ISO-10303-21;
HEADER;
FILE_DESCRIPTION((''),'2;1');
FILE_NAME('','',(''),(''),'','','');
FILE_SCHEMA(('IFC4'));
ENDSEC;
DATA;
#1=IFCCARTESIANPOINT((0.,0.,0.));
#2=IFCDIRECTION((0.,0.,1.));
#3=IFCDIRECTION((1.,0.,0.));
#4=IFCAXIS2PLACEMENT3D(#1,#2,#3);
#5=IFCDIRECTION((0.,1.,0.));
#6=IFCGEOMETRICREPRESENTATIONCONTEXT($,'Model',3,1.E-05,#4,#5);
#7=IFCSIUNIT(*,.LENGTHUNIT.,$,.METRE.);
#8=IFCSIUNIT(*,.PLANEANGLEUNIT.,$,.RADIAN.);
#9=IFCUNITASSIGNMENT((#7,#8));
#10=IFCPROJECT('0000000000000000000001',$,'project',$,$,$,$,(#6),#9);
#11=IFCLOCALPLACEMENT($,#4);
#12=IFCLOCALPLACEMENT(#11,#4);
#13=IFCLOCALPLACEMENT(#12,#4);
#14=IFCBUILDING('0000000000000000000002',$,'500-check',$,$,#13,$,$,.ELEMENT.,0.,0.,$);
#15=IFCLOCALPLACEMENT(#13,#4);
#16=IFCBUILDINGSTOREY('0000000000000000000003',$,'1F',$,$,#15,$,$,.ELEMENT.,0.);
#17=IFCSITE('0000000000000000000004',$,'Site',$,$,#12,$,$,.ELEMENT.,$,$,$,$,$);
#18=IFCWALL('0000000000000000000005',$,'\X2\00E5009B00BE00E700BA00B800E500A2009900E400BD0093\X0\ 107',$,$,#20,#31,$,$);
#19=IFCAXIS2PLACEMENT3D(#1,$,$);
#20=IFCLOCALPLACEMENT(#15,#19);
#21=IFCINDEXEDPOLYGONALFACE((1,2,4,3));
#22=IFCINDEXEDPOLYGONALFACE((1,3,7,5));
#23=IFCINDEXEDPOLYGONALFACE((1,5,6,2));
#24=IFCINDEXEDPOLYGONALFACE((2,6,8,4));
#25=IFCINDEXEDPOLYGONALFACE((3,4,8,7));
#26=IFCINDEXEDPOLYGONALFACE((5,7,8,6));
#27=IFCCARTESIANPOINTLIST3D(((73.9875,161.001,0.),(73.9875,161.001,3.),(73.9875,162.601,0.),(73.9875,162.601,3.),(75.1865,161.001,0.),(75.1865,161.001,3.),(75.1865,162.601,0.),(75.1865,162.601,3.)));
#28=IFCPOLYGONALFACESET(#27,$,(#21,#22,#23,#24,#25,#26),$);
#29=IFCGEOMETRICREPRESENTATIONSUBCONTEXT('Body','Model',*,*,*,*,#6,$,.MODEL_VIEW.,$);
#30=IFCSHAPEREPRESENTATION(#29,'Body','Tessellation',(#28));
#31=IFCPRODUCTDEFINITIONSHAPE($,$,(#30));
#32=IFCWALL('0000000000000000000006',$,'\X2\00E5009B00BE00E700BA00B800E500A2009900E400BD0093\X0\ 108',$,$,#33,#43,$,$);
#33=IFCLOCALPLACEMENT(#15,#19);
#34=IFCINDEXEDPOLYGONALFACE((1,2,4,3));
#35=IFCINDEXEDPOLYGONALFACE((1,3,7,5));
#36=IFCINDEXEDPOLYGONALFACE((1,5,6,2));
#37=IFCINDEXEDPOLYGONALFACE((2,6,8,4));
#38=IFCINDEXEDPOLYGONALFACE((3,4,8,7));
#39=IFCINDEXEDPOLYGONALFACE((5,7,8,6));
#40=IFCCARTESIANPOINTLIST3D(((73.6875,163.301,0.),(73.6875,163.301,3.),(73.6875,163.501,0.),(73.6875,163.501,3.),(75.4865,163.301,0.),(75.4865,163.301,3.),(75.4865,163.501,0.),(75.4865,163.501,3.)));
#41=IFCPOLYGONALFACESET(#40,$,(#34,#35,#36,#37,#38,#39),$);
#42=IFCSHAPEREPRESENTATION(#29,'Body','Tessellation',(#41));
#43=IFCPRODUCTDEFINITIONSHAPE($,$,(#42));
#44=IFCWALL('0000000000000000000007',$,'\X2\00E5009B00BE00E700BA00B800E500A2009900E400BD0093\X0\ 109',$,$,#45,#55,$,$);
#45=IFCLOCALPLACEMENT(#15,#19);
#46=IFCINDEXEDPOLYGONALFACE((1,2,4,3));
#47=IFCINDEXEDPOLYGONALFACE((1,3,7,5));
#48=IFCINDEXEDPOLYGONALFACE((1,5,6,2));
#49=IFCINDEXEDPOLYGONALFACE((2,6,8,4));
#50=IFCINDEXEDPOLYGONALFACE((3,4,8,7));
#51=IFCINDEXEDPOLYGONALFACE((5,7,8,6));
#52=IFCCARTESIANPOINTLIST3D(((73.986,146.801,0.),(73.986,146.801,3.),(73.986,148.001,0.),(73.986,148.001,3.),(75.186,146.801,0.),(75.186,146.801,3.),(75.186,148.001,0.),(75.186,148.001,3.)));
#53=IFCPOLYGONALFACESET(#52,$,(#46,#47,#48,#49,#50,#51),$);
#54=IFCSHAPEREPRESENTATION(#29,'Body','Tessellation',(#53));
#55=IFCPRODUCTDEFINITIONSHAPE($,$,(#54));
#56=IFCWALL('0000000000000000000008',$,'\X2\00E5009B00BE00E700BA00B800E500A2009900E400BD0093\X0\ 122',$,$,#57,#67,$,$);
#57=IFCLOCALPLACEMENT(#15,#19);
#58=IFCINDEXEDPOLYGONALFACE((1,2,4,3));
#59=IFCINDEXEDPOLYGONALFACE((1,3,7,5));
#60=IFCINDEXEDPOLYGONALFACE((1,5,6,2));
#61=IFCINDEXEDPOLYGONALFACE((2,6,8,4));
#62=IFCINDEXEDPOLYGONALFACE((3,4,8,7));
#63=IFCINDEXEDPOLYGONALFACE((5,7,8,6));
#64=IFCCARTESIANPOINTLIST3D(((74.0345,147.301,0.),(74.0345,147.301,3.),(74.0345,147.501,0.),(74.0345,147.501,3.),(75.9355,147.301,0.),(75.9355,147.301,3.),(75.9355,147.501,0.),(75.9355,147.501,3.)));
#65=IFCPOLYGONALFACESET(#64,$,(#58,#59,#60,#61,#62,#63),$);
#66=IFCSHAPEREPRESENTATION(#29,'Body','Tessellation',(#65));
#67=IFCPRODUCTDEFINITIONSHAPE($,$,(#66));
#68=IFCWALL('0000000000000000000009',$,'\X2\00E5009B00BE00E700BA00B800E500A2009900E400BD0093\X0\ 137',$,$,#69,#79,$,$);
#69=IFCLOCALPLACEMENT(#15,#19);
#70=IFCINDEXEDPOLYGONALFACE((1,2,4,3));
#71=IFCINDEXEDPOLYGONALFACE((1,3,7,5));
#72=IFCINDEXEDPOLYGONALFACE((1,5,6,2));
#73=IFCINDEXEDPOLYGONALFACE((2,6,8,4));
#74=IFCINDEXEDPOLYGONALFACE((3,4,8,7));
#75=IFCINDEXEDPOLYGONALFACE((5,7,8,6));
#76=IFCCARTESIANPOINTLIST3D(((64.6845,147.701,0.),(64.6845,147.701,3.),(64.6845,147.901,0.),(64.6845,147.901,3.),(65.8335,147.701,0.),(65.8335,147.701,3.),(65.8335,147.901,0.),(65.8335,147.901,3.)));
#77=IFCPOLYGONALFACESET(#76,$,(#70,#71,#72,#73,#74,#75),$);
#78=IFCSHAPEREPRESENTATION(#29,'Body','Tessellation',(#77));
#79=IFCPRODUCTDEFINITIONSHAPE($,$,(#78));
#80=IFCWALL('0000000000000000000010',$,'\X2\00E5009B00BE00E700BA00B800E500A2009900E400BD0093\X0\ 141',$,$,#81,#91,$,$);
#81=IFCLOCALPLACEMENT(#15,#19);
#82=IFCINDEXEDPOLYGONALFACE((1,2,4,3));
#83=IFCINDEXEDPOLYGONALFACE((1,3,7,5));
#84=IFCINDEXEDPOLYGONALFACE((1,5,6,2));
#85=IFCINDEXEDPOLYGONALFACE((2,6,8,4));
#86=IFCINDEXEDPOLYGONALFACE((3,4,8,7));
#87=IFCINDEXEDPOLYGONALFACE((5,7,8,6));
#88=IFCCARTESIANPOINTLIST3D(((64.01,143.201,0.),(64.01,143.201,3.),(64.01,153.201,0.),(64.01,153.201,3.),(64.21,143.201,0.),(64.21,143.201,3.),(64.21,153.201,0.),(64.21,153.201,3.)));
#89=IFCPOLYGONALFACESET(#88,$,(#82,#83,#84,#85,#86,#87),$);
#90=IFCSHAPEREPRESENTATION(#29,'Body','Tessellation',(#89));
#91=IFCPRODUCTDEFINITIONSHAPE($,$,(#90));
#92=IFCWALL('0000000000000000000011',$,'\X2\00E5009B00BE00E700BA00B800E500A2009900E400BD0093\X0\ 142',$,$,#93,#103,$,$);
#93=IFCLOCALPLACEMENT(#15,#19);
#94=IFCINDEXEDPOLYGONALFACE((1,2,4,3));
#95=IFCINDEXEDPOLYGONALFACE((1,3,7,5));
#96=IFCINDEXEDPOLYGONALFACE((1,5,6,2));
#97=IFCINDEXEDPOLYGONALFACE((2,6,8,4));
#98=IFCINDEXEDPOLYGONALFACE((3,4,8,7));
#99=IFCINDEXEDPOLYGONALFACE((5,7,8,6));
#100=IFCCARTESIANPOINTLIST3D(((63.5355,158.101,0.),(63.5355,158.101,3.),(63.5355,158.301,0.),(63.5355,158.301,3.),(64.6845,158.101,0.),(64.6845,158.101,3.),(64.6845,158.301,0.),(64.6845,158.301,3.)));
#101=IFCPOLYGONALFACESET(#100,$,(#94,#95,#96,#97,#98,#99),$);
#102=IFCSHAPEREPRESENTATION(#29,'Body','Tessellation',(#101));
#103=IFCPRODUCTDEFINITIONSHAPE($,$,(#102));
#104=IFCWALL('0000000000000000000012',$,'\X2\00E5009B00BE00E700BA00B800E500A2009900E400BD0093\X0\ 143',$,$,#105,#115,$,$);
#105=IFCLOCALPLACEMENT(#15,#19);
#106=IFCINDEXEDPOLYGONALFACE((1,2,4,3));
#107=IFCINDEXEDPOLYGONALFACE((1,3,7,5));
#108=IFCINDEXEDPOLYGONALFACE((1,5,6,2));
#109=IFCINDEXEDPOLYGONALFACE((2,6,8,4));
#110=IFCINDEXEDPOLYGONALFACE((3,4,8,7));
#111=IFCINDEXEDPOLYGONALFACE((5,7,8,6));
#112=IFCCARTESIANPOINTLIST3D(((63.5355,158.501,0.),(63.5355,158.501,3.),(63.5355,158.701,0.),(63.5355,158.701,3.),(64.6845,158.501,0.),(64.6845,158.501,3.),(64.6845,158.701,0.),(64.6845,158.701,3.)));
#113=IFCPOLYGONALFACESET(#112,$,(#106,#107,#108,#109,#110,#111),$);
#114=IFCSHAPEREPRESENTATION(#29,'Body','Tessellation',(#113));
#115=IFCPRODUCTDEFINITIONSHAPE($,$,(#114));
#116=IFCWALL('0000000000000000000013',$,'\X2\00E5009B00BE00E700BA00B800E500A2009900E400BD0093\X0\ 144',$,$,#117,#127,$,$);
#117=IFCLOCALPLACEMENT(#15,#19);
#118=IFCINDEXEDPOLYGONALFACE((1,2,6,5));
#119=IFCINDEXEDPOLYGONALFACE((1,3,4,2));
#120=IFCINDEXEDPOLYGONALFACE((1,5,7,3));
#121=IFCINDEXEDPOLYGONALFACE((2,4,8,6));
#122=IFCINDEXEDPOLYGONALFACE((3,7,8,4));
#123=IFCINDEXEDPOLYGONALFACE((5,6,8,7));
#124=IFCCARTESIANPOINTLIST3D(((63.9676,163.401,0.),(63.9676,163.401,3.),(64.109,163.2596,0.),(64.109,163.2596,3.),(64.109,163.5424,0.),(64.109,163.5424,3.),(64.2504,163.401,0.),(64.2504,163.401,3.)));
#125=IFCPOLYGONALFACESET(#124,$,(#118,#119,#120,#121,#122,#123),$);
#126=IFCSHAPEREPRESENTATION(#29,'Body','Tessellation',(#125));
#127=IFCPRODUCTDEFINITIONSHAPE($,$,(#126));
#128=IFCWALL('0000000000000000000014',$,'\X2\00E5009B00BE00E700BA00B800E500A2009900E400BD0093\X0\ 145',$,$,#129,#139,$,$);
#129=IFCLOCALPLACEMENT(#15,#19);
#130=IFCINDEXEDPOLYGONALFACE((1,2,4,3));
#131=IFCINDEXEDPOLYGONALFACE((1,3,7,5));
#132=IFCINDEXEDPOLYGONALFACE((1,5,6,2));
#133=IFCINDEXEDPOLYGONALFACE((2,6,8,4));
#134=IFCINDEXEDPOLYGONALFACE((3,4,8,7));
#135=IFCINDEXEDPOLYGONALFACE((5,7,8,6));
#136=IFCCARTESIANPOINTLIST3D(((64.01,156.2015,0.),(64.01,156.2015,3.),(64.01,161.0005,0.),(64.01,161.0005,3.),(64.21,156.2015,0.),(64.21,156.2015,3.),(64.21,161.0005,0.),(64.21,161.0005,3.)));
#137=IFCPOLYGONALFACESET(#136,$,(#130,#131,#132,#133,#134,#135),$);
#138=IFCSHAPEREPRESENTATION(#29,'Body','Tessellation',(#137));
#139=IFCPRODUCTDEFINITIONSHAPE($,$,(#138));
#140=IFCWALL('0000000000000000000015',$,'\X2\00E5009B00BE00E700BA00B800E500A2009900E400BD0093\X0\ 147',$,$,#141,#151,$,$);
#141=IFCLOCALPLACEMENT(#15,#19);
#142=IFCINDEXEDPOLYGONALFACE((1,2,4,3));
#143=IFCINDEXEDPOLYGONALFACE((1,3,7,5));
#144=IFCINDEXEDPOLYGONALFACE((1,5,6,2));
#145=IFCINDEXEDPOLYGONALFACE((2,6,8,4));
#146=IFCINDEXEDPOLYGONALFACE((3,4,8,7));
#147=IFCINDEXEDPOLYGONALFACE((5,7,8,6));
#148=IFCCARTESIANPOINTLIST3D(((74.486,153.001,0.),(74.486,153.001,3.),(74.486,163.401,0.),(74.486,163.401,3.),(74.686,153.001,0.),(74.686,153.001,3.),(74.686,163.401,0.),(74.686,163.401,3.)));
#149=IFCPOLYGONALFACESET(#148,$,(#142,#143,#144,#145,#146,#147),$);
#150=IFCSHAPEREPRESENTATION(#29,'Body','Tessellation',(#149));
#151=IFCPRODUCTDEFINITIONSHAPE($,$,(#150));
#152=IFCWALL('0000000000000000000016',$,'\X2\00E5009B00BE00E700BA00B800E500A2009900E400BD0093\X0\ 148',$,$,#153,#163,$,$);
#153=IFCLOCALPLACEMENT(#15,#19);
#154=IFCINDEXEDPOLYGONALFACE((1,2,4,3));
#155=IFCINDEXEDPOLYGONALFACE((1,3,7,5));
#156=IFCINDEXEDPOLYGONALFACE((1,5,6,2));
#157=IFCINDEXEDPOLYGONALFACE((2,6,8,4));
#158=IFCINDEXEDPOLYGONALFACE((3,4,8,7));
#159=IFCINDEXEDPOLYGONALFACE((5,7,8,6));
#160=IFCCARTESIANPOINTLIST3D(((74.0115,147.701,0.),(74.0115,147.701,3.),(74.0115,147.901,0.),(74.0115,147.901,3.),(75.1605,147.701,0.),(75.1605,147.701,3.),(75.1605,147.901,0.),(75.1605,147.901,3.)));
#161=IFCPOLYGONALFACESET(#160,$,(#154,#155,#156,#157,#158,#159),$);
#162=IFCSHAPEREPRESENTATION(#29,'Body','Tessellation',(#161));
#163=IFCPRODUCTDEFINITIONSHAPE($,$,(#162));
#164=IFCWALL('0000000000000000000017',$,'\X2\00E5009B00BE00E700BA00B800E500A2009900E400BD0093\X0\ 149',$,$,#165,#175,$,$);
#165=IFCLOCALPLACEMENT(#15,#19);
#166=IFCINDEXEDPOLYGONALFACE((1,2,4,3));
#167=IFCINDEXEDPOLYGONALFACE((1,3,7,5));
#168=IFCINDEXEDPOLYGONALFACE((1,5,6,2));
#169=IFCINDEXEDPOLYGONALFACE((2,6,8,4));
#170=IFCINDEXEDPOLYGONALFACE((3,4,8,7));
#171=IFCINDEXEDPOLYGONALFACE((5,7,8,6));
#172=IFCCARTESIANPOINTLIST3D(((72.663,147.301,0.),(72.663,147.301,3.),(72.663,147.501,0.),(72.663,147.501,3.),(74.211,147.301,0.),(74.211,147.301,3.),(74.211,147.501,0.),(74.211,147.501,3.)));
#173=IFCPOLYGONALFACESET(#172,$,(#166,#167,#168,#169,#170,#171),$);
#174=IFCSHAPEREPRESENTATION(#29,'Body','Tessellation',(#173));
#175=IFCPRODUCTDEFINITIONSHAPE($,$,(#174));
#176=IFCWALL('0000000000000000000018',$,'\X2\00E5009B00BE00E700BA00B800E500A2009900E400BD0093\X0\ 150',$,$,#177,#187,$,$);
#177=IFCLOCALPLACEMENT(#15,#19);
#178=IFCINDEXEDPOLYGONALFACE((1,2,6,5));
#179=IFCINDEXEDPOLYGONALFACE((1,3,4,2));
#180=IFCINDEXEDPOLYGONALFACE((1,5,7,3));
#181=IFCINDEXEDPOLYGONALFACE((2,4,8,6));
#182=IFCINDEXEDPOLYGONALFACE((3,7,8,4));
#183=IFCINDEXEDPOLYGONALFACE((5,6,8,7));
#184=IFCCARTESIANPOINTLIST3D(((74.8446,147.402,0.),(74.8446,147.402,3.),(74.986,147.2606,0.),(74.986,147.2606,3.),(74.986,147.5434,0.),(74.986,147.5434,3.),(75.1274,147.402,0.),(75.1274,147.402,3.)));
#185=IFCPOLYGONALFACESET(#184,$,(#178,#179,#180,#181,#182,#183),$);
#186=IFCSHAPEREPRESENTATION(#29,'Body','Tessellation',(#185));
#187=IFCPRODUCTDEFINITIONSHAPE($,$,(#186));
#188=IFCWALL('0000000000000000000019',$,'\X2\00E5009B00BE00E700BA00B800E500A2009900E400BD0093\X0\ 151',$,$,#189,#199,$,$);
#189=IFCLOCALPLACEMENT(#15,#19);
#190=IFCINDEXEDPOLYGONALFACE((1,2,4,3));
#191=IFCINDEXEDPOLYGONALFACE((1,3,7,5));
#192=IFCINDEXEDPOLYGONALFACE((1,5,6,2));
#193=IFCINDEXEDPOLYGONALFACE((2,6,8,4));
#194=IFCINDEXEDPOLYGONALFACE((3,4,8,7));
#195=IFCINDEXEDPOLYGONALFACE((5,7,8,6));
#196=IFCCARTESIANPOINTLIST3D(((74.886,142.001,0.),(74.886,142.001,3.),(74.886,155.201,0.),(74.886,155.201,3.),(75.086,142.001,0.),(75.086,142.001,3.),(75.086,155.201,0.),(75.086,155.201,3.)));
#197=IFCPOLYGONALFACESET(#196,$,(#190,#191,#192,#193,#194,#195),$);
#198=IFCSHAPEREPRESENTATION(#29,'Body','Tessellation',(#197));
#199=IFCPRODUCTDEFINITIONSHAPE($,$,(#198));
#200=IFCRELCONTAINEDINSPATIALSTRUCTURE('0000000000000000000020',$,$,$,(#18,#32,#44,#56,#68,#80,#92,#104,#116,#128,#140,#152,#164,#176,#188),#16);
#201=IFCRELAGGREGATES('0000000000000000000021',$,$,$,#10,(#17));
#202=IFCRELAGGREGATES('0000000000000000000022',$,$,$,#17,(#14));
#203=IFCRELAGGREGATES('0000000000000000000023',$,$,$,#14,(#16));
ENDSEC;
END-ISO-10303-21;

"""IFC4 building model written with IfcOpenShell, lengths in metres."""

from ifc_helpers import new_model, si_unit, direction, frame, frame_2d, origin_with_axes, place, context, subcontext, project, spatial, rectangle, extrude, element, save


model = new_model("IFC4")

# Units and contexts
model_context = context("Model", 3, precision=1e-05, world=origin_with_axes(), true_north=direction((0.0, 1.0, 0.0)))
body_context = subcontext(model_context, "Body", "Model", "MODEL_VIEW")
ifc_project = project(units=[si_unit("LENGTHUNIT", "METRE"), si_unit("PLANEANGLEUNIT", "RADIAN")], contexts=[model_context])

# Site, building, storey
placement = place(None, origin_with_axes())
site_placement = place(placement, origin_with_axes())
site = spatial("IfcSite", under=ifc_project, at=site_placement, Name="Site", CompositionType="ELEMENT")
building_placement = place(site_placement, origin_with_axes())
building = spatial("IfcBuilding", under=site, at=building_placement, Name="500-check", CompositionType="ELEMENT", ElevationOfRefHeight=0.0, ElevationOfTerrain=0.0)
storey_placement = place(building_placement, origin_with_axes())
storey = spatial("IfcBuildingStorey", under=building, at=storey_placement, Name="1F", CompositionType="ELEMENT", Elevation=0.0)

# Walls
wall_1_placement = place(storey_placement, frame((74.587, 161.801, 0.0), z_axis=(0.0, 0.0, 1.0), x_axis=(1.0, 0.0, 0.0)))
element("IfcWall", 1, at=wall_1_placement, inside=storey, Name="å\u009b¾çº¸å¢\u0099ä½\u0093 107", context=body_context, shape_type="SweptSolid", body=[
    extrude(rectangle(XDim=1.199, YDim=1.6, at=frame_2d((0.0, 0.0), x_axis=(1.0, 0.0, 0.0))), frame((0.0, 0.0, 0.0), z_axis=(0.0, 0.0, 1.0)), (0.0, 0.0, 1.0), 3.0),
])
wall_2_placement = place(storey_placement, frame((74.587, 163.401, 0.0), z_axis=(0.0, 0.0, 1.0), x_axis=(1.0, 0.0, 0.0)))
element("IfcWall", 2, at=wall_2_placement, inside=storey, Name="å\u009b¾çº¸å¢\u0099ä½\u0093 108", context=body_context, shape_type="SweptSolid", body=[
    extrude(rectangle(XDim=1.799, YDim=0.2, at=frame_2d((0.0, 0.0), x_axis=(1.0, 0.0, 0.0))), frame((0.0, 0.0, 0.0), z_axis=(0.0, 0.0, 1.0)), (0.0, 0.0, 1.0), 3.0),
])
wall_3_placement = place(storey_placement, frame((74.586, 147.401, 0.0), z_axis=(0.0, 0.0, 1.0), x_axis=(1.0, 0.0, 0.0)))
element("IfcWall", 3, at=wall_3_placement, inside=storey, Name="å\u009b¾çº¸å¢\u0099ä½\u0093 109", context=body_context, shape_type="SweptSolid", body=[
    extrude(rectangle(XDim=1.2, YDim=1.2, at=frame_2d((0.0, 0.0), x_axis=(1.0, 0.0, 0.0))), frame((0.0, 0.0, 0.0), z_axis=(0.0, 0.0, 1.0)), (0.0, 0.0, 1.0), 3.0),
])
wall_4_placement = place(storey_placement, frame((74.985, 147.401, 0.0), z_axis=(0.0, 0.0, 1.0), x_axis=(1.0, 0.0, 0.0)))
element("IfcWall", 4, at=wall_4_placement, inside=storey, Name="å\u009b¾çº¸å¢\u0099ä½\u0093 122", context=body_context, shape_type="SweptSolid", body=[
    extrude(rectangle(XDim=1.901, YDim=0.2, at=frame_2d((0.0, 0.0), x_axis=(1.0, 0.0, 0.0))), frame((0.0, 0.0, 0.0), z_axis=(0.0, 0.0, 1.0)), (0.0, 0.0, 1.0), 3.0),
])
wall_5_placement = place(storey_placement, frame((65.259, 147.801, 0.0), z_axis=(0.0, 0.0, 1.0), x_axis=(-1.0, 0.0, 0.0)))
element("IfcWall", 5, at=wall_5_placement, inside=storey, Name="å\u009b¾çº¸å¢\u0099ä½\u0093 137", context=body_context, shape_type="SweptSolid", body=[
    extrude(rectangle(XDim=1.149, YDim=0.2, at=frame_2d((0.0, 0.0), x_axis=(1.0, 0.0, 0.0))), frame((0.0, 0.0, 0.0), z_axis=(0.0, 0.0, 1.0)), (0.0, 0.0, 1.0), 3.0),
])
wall_6_placement = place(storey_placement, frame((64.11, 148.201, 0.0), z_axis=(0.0, 0.0, 1.0), x_axis=(0.0, 1.0, 0.0)))
element("IfcWall", 6, at=wall_6_placement, inside=storey, Name="å\u009b¾çº¸å¢\u0099ä½\u0093 141", context=body_context, shape_type="SweptSolid", body=[
    extrude(rectangle(XDim=10.0, YDim=0.2, at=frame_2d((0.0, 0.0), x_axis=(1.0, 0.0, 0.0))), frame((0.0, 0.0, 0.0), z_axis=(0.0, 0.0, 1.0)), (0.0, 0.0, 1.0), 3.0),
])
for number, where, z_axis, x_axis, name in (
    (7, (64.11, 158.201, 0.0), (0.0, 0.0, 1.0), (1.0, 0.0, 0.0), "å\u009b¾çº¸å¢\u0099ä½\u0093 142"),
    (8, (64.11, 158.601, 0.0), (0.0, 0.0, 1.0), (1.0, 0.0, 0.0), "å\u009b¾çº¸å¢\u0099ä½\u0093 143"),
):
    element("IfcWall", number, at=place(storey_placement, frame(where, z_axis=z_axis, x_axis=x_axis)), inside=storey, Name=name, context=body_context, shape_type="SweptSolid", body=[
        extrude(rectangle(XDim=1.149, YDim=0.2, at=frame_2d((0.0, 0.0), x_axis=(1.0, 0.0, 0.0))), frame((0.0, 0.0, 0.0), z_axis=(0.0, 0.0, 1.0)), (0.0, 0.0, 1.0), 3.0),
    ])
wall_7_placement = place(storey_placement, frame((64.109, 163.401, 0.0), z_axis=(0.0, 0.0, 1.0), x_axis=(0.707107, -0.707107, 0.0)))
element("IfcWall", 9, at=wall_7_placement, inside=storey, Name="å\u009b¾çº¸å¢\u0099ä½\u0093 144", context=body_context, shape_type="SweptSolid", body=[
    extrude(rectangle(XDim=0.2, YDim=0.2, at=frame_2d((0.0, 0.0), x_axis=(1.0, 0.0, 0.0))), frame((0.0, 0.0, 0.0), z_axis=(0.0, 0.0, 1.0)), (0.0, 0.0, 1.0), 3.0),
])
wall_8_placement = place(storey_placement, frame((64.11, 158.601, 0.0), z_axis=(0.0, 0.0, 1.0), x_axis=(0.0, 1.0, 0.0)))
element("IfcWall", 10, at=wall_8_placement, inside=storey, Name="å\u009b¾çº¸å¢\u0099ä½\u0093 145", context=body_context, shape_type="SweptSolid", body=[
    extrude(rectangle(XDim=4.799, YDim=0.2, at=frame_2d((0.0, 0.0), x_axis=(1.0, 0.0, 0.0))), frame((0.0, 0.0, 0.0), z_axis=(0.0, 0.0, 1.0)), (0.0, 0.0, 1.0), 3.0),
])
wall_9_placement = place(storey_placement, frame((74.586, 158.201, 0.0), z_axis=(0.0, 0.0, 1.0), x_axis=(0.0, -1.0, 0.0)))
element("IfcWall", 11, at=wall_9_placement, inside=storey, Name="å\u009b¾çº¸å¢\u0099ä½\u0093 147", context=body_context, shape_type="SweptSolid", body=[
    extrude(rectangle(XDim=10.4, YDim=0.2, at=frame_2d((0.0, 0.0), x_axis=(1.0, 0.0, 0.0))), frame((0.0, 0.0, 0.0), z_axis=(0.0, 0.0, 1.0)), (0.0, 0.0, 1.0), 3.0),
])
wall_10_placement = place(storey_placement, frame((74.586, 147.801, 0.0), z_axis=(0.0, 0.0, 1.0), x_axis=(-1.0, 0.0, 0.0)))
element("IfcWall", 12, at=wall_10_placement, inside=storey, Name="å\u009b¾çº¸å¢\u0099ä½\u0093 148", context=body_context, shape_type="SweptSolid", body=[
    extrude(rectangle(XDim=1.149, YDim=0.2, at=frame_2d((0.0, 0.0), x_axis=(1.0, 0.0, 0.0))), frame((0.0, 0.0, 0.0), z_axis=(0.0, 0.0, 1.0)), (0.0, 0.0, 1.0), 3.0),
])
wall_11_placement = place(storey_placement, frame((73.437, 147.401, 0.0), z_axis=(0.0, 0.0, 1.0), x_axis=(1.0, 0.0, 0.0)))
element("IfcWall", 13, at=wall_11_placement, inside=storey, Name="å\u009b¾çº¸å¢\u0099ä½\u0093 149", context=body_context, shape_type="SweptSolid", body=[
    extrude(rectangle(XDim=1.548, YDim=0.2, at=frame_2d((0.0, 0.0), x_axis=(1.0, 0.0, 0.0))), frame((0.0, 0.0, 0.0), z_axis=(0.0, 0.0, 1.0)), (0.0, 0.0, 1.0), 3.0),
])
wall_12_placement = place(storey_placement, frame((74.986, 147.402, 0.0), z_axis=(0.0, 0.0, 1.0), x_axis=(-0.707107, -0.707107, 0.0)))
element("IfcWall", 14, at=wall_12_placement, inside=storey, Name="å\u009b¾çº¸å¢\u0099ä½\u0093 150", context=body_context, shape_type="SweptSolid", body=[
    extrude(rectangle(XDim=0.2, YDim=0.2, at=frame_2d((0.0, 0.0), x_axis=(1.0, 0.0, 0.0))), frame((0.0, 0.0, 0.0), z_axis=(0.0, 0.0, 1.0)), (0.0, 0.0, 1.0), 3.0),
])
wall_13_placement = place(storey_placement, frame((74.986, 148.601, 0.0), z_axis=(0.0, 0.0, 1.0), x_axis=(0.0, 1.0, 0.0)))
element("IfcWall", 15, at=wall_13_placement, inside=storey, Name="å\u009b¾çº¸å¢\u0099ä½\u0093 151", context=body_context, shape_type="SweptSolid", body=[
    extrude(rectangle(XDim=13.2, YDim=0.2, at=frame_2d((0.0, 0.0), x_axis=(1.0, 0.0, 0.0))), frame((0.0, 0.0, 0.0), z_axis=(0.0, 0.0, 1.0)), (0.0, 0.0, 1.0), 3.0),
])

save(model, "model.ifc")
